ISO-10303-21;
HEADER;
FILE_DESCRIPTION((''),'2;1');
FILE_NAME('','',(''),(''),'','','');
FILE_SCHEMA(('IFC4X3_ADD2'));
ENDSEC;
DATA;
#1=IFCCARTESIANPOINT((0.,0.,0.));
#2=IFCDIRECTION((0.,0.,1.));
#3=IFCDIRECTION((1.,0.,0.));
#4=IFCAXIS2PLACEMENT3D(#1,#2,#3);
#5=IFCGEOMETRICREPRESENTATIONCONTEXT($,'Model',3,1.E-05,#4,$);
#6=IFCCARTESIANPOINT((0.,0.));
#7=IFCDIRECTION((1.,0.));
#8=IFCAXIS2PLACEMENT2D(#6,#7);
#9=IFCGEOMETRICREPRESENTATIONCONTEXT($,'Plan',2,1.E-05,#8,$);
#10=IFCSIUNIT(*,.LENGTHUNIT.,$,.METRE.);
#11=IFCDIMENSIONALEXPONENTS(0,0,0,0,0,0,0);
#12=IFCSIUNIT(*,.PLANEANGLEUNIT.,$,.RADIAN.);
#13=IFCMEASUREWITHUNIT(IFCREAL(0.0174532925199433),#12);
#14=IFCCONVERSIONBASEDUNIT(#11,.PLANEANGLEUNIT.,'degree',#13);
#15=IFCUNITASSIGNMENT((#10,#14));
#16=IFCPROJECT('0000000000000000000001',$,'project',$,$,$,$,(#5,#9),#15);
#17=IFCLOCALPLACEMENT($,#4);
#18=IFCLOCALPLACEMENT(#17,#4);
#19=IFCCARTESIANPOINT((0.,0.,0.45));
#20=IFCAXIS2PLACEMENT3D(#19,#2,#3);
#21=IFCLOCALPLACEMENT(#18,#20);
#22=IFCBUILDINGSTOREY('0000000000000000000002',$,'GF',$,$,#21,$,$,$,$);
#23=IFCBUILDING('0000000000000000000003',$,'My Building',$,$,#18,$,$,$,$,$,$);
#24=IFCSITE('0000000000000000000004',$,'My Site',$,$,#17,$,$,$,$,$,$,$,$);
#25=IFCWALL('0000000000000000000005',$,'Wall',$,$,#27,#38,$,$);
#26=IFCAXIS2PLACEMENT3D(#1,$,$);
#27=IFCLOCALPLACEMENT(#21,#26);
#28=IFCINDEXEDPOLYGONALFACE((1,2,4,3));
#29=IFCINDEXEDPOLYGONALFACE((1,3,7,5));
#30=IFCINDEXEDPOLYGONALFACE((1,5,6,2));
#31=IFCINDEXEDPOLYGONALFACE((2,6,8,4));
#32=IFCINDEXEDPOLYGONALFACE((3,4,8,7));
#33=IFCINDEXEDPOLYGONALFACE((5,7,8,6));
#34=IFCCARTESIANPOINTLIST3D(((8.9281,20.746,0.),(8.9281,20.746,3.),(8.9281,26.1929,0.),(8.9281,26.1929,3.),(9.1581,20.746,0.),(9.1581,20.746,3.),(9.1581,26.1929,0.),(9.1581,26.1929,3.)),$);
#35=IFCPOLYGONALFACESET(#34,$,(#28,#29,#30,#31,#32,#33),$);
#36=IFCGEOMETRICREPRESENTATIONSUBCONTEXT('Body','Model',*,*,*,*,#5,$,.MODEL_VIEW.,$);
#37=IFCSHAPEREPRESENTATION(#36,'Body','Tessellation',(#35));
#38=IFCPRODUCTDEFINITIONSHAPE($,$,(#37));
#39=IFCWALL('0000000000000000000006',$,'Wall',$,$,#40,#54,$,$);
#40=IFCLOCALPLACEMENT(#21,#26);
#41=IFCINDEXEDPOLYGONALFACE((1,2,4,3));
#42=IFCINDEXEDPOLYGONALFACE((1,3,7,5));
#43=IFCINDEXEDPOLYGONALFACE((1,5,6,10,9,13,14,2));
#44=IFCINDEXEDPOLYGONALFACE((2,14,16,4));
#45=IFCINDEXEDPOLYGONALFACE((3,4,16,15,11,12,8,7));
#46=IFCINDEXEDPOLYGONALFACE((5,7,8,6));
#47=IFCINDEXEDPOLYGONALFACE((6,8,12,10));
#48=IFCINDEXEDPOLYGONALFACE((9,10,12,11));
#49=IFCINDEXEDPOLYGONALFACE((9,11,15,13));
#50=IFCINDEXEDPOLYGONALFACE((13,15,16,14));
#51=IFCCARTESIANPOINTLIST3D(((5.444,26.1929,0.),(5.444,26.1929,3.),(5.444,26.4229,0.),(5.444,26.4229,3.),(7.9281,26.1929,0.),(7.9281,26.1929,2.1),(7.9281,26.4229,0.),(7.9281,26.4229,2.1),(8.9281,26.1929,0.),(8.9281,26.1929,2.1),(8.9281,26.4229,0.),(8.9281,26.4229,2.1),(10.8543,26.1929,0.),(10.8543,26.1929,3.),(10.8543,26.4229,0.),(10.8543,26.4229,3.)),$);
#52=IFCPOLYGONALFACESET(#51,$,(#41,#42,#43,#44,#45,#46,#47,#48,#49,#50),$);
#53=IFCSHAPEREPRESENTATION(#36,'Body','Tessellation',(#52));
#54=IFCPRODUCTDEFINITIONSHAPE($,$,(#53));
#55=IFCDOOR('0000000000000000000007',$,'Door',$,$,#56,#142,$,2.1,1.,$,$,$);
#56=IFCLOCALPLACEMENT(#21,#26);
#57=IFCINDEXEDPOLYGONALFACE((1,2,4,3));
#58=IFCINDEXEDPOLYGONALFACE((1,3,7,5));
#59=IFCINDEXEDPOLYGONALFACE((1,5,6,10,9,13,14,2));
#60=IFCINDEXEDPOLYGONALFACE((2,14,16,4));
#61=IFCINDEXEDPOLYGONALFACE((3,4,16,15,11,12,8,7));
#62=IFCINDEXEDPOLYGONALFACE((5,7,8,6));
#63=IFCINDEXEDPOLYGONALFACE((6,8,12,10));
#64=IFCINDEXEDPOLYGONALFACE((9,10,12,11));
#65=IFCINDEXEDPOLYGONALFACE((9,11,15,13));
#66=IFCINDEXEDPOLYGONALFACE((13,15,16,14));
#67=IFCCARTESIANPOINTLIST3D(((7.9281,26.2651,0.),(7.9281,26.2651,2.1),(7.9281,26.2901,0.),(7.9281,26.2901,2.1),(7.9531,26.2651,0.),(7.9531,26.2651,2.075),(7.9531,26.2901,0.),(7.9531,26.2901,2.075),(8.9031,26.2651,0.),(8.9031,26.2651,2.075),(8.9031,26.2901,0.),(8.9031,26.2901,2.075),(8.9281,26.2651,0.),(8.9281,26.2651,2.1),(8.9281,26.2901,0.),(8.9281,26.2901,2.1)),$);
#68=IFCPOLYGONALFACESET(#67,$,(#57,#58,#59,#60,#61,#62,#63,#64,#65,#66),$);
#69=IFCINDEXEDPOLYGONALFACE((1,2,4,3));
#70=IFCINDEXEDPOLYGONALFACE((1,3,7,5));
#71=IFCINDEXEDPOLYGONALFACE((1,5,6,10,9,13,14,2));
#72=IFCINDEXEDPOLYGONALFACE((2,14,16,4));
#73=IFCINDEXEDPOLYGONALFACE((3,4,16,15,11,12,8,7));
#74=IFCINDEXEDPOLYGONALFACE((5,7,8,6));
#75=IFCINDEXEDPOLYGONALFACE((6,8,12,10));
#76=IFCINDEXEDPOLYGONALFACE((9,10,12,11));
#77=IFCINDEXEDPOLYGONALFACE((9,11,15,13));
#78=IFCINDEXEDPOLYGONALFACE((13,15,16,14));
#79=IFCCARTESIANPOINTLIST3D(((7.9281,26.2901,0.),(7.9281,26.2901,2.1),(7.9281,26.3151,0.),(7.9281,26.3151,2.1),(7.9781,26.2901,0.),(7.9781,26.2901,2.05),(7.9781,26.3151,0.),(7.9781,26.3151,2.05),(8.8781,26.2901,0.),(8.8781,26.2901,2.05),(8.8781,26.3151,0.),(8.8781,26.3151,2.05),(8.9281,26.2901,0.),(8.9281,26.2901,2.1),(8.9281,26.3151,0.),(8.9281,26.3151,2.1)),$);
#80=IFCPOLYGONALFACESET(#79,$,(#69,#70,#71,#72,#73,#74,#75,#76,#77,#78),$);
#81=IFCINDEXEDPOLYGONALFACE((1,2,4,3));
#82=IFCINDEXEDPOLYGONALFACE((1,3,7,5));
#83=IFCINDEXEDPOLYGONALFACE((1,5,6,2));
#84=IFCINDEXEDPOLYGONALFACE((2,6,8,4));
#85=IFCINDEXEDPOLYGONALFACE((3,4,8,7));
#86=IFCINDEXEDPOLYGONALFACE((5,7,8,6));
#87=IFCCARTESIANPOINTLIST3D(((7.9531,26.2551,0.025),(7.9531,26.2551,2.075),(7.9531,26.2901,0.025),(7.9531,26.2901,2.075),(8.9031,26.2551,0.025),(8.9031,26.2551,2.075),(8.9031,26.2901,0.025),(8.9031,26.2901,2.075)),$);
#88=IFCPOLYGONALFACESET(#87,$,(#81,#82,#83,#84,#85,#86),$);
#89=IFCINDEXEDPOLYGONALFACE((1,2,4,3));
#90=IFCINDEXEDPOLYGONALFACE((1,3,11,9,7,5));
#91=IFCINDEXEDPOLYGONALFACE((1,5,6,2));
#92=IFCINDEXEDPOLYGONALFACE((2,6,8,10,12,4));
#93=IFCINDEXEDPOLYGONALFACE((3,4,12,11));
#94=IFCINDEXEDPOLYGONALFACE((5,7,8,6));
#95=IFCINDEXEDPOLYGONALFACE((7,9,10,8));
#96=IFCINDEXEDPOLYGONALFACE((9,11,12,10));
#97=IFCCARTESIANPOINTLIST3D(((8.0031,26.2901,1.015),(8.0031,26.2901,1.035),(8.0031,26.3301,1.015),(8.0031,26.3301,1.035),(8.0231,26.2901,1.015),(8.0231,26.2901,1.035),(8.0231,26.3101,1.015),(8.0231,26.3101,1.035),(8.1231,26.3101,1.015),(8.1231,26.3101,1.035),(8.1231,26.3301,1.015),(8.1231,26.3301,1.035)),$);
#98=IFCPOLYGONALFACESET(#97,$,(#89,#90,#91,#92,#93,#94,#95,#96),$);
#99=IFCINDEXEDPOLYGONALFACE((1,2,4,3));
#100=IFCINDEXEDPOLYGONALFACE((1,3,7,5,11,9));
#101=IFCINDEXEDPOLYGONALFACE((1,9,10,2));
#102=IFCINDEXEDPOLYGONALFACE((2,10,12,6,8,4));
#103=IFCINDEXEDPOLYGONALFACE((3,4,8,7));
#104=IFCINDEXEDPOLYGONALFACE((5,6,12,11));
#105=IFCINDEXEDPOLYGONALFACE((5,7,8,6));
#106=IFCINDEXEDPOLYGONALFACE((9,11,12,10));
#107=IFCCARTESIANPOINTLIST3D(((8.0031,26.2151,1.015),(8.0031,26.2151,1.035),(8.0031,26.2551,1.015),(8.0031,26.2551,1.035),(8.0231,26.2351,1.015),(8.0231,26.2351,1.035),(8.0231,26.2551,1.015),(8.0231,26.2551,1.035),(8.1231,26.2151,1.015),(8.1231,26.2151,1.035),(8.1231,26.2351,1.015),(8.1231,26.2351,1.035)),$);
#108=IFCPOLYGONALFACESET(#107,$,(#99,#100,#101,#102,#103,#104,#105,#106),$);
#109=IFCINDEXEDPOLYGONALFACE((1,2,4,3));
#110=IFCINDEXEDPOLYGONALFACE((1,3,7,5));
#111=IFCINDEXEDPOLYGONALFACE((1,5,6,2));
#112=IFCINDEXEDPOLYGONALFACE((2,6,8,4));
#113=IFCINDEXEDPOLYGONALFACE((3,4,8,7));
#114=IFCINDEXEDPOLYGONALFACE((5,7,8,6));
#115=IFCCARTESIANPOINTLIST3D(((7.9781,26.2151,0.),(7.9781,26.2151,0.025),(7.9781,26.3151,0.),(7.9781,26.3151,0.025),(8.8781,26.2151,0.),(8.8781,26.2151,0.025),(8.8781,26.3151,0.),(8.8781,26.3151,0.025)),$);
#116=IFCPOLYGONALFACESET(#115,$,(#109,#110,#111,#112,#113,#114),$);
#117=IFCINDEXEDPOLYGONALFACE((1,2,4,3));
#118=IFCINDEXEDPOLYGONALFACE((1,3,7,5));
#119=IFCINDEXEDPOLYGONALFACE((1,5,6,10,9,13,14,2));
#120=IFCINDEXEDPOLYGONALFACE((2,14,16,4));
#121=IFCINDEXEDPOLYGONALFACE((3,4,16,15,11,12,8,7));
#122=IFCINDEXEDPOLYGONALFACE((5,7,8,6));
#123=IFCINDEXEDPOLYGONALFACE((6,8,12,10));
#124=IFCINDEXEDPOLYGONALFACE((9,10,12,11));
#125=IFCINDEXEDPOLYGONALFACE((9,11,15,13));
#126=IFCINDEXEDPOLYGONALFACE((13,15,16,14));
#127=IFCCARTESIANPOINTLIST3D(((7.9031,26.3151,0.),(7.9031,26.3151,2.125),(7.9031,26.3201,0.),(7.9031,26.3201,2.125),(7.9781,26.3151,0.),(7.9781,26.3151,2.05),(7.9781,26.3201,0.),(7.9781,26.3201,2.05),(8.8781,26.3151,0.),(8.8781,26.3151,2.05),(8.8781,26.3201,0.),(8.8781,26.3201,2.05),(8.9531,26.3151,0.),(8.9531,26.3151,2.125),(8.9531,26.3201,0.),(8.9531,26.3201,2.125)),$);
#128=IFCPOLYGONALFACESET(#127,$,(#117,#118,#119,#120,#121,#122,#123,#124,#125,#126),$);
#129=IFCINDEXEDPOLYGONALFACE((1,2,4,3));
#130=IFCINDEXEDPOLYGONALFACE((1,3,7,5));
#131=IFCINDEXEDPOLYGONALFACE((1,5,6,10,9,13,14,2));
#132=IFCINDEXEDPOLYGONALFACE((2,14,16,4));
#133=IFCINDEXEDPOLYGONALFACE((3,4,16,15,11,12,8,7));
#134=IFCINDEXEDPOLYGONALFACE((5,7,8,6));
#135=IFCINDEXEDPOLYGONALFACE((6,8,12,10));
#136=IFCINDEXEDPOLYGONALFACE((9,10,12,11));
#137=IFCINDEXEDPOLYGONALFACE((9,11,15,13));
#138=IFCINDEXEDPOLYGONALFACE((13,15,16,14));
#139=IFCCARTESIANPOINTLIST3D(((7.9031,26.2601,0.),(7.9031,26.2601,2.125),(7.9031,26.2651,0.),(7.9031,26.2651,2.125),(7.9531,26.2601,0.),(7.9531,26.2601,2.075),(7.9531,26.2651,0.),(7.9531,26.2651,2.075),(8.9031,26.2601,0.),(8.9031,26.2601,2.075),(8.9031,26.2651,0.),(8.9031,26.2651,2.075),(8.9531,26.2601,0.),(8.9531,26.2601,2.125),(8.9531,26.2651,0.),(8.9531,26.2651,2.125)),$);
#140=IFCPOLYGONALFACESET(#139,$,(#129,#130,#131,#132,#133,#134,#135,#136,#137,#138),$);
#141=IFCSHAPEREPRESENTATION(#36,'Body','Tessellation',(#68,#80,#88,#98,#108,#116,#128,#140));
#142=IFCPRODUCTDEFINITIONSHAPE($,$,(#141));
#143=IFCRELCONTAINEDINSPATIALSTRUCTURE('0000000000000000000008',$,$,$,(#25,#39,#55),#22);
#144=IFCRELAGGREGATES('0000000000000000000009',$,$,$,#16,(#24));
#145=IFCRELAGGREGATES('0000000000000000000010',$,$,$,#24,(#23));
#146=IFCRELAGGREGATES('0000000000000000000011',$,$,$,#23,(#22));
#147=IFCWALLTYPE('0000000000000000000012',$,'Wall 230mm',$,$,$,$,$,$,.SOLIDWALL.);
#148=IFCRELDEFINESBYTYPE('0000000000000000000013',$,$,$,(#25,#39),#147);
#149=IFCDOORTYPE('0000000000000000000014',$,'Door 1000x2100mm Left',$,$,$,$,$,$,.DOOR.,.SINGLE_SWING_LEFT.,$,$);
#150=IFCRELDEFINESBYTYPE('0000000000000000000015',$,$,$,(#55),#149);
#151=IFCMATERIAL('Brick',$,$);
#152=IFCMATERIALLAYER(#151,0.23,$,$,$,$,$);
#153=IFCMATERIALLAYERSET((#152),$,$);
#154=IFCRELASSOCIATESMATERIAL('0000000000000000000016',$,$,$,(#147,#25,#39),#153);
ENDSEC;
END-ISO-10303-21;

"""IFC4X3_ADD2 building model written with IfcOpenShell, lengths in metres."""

from ifc_helpers import new_model, entity, si_unit, converted_unit, frame, origin_with_axes, origin_2d_with_axis, place, context, subcontext, project, spatial, line, indexed_curve, outline, extrude, shape, source, transform, mapped, material, layer, layer_set, layer_usage, type_object, type_shapes, element, fill, save


model = new_model("IFC4X3_ADD2")

# Units and contexts
model_context = context("Model", 3, precision=1e-05, world=origin_with_axes())
plan_context = context("Plan", 2, precision=1e-05, world=origin_2d_with_axis())
body_context_1 = subcontext(model_context, "Body", "Model", "MODEL_VIEW")
body_context_2 = subcontext(plan_context, "Body", "Plan", "PLAN_VIEW")
ifc_project = project(units=[si_unit("LENGTHUNIT", "METRE"), converted_unit("PLANEANGLEUNIT", "degree", entity("IfcReal", 0.0174532925199433), si_unit("PLANEANGLEUNIT", "RADIAN"), dimensions=[0, 0, 0, 0, 0, 0, 0])], contexts=[model_context, plan_context])

# Site, building, storey
site_placement = place(None, origin_with_axes())
site = spatial("IfcSite", under=ifc_project, at=site_placement, Name="My Site")
building_placement = place(site_placement, origin_with_axes())
building = spatial("IfcBuilding", under=site, at=building_placement, Name="My Building")
storey_placement = place(building_placement, frame((0.0, 0.0, 0.45), z_axis=(0.0, 0.0, 1.0), x_axis=(1.0, 0.0, 0.0)))
storey = spatial("IfcBuildingStorey", under=building, at=storey_placement, Name="GF")

# Wall
ifc_material = material(Name="Brick")
ifc_layer_1 = layer(ifc_material, 0.23)
ifc_layer_set_1 = layer_set([ifc_layer_1])
ifc_layer_usage_1 = layer_usage(ifc_layer_set_1, "AXIS2", "POSITIVE", 0.0)
wall_type_1 = type_object("IfcWallType", Name="Wall 230mm", PredefinedType="SOLIDWALL", material=ifc_layer_set_1)
wall_1_placement = place(storey_placement, frame((9.1581, 20.746, 0.0), z_axis=(0.0, 0.0, 1.0), x_axis=(0.0, 1.0, 0.0)))
element("IfcWall", 1, at=wall_1_placement, inside=storey, type_object=wall_type_1, material=ifc_layer_usage_1, Name="Wall", context=body_context_1, shape_type="SweptSolid", body=[
    extrude(outline(indexed_curve([(0.0, 0.0), (0.0, 0.23), (5.4469, 0.23), (5.4469, 0.0), (0.0, 0.0)], self_intersect=False)), origin_with_axes(), (0.0, 0.0, 1.0), 3.0),
])

# Wall, opening, door
ifc_layer_usage_2 = layer_usage(ifc_layer_set_1, "AXIS2", "POSITIVE", 0.0)
wall_2_placement = place(storey_placement, frame((5.444, 26.1929, 0.0), z_axis=(0.0, 0.0, 1.0), x_axis=(1.0, 0.0, 0.0)))
wall_2 = element("IfcWall", 2, at=wall_2_placement, inside=storey, type_object=wall_type_1, material=ifc_layer_usage_2, Name="Wall", context=body_context_1, shape_type="SweptSolid", body=[
    extrude(outline(indexed_curve([(0.0, 0.0), (0.0, 0.23), (5.4103, 0.23), (5.4103, 0.0), (0.0, 0.0)], self_intersect=False)), origin_with_axes(), (0.0, 0.0, 1.0), 3.0),
])
shared_shape_1 = source(origin_with_axes(), body_context_1, "Body", "SweptSolid", [
    extrude(outline(indexed_curve([(0.0, 0.0), (1.0, 0.0), (1.0, 2.1), (0.0, 2.1)], segments=[line(1, 2, 3, 4, 1)])), frame((0.0, -0.6, 0.0), z_axis=(0.0, -1.0, 0.0), x_axis=(1.0, 0.0, 0.0)), (0.0, 0.0, -1.0), 1.2),
])
opening_1_placement = place(wall_2_placement, frame((3.4841, 0.1222, 0.0), z_axis=(0.0, 0.0, 1.0), x_axis=(-1.0, 0.0, 0.0)))
opening_1 = element("IfcOpeningElement", 3, at=opening_1_placement, cuts=wall_2, PredefinedType="OPENING", context=body_context_1, shape_type="MappedRepresentation", body=[
    mapped(shared_shape_1, transform((0.0, 0.0, 0.0), x_axis=(1.0, 0.0, 0.0), y_axis=(0.0, 1.0, 0.0), z_axis=(0.0, 0.0, 1.0), scale=1.0)),
])
door_type_1 = type_object("IfcDoorType", Name="Door 1000x2100mm Left", OperationType="SINGLE_SWING_LEFT", PredefinedType="DOOR")
shared_shape_2 = source(origin_with_axes(), body_context_1, "Body", "SweptSolid", [
    extrude(outline(indexed_curve([(0.0, 0.0), (0.0, 2.1), (1.0, 2.1), (1.0, 0.0), (0.975, 0.0), (0.975, 2.075), (0.025, 2.075), (0.025, 0.0)], segments=[line(1, 2, 3, 4, 5, 6, 7, 8, 1)])), frame((0.0, 0.025, 0.0), z_axis=(0.0, -1.0, 0.0), x_axis=(1.0, 0.0, 0.0)), (0.0, 0.0, -1.0), 0.025),
    extrude(outline(indexed_curve([(0.0, 0.0), (0.0, 2.1), (1.0, 2.1), (1.0, 0.0), (0.95, 0.0), (0.95, 2.05), (0.05, 2.05), (0.05, 0.0)], segments=[line(1, 2, 3, 4, 5, 6, 7, 8, 1)])), frame((0.0, 0.0, 0.0), z_axis=(0.0, -1.0, 0.0), x_axis=(1.0, 0.0, 0.0)), (0.0, 0.0, -1.0), 0.025),
    extrude(outline(indexed_curve([(0.0, 0.0), (0.95, 0.0), (0.95, 0.035), (0.0, 0.035)], segments=[line(1, 2, 3, 4, 1)])), frame((0.025, 0.025, 0.025), z_axis=(0.0, 0.0, 1.0), x_axis=(1.0, 0.0, 0.0)), (0.0, 0.0, 1.0), 2.05),
    extrude(outline(indexed_curve([(0.0, 0.0), (0.0, -0.04), (-0.12, -0.04), (-0.12, -0.02), (-0.02, -0.02), (-0.02, 0.0)], segments=[line(1, 2, 3, 4, 5, 6, 1)])), frame((0.925, 0.025, 1.015), z_axis=(0.0, 0.0, 1.0), x_axis=(1.0, 0.0, 0.0)), (0.0, 0.0, 1.0), 0.02),
    extrude(outline(indexed_curve([(0.0, 0.0), (0.0, 0.04), (-0.12, 0.04), (-0.12, 0.02), (-0.02, 0.02), (-0.02, 0.0)], segments=[line(1, 2, 3, 4, 5, 6, 1)])), frame((0.925, 0.06, 1.015), z_axis=(0.0, 0.0, 1.0), x_axis=(1.0, 0.0, 0.0)), (0.0, 0.0, 1.0), 0.02),
    extrude(outline(indexed_curve([(0.0, 0.0), (0.9, 0.0), (0.9, 0.1), (0.0, 0.1)], segments=[line(1, 2, 3, 4, 1)])), frame((0.05, 0.0, 0.0), z_axis=(0.0, 0.0, 1.0), x_axis=(1.0, 0.0, 0.0)), (0.0, 0.0, 1.0), 0.025),
    extrude(outline(indexed_curve([(0.0, 0.0), (0.0, 2.125), (1.05, 2.125), (1.05, 0.0), (0.975, 0.0), (0.975, 2.05), (0.075, 2.05), (0.075, 0.0)], segments=[line(1, 2, 3, 4, 5, 6, 7, 8, 1)])), frame((-0.025, -0.005, 0.0), z_axis=(0.0, -1.0, 0.0), x_axis=(1.0, 0.0, 0.0)), (0.0, 0.0, -1.0), 0.005),
    extrude(outline(indexed_curve([(0.0, 0.0), (0.0, 2.125), (1.05, 2.125), (1.05, 0.0), (1.0, 0.0), (1.0, 2.075), (0.05, 2.075), (0.05, 0.0)], segments=[line(1, 2, 3, 4, 5, 6, 7, 8, 1)])), frame((-0.025, 0.05, 0.0), z_axis=(0.0, -1.0, 0.0), x_axis=(1.0, 0.0, 0.0)), (0.0, 0.0, -1.0), 0.005),
])
shared_shape_3 = source(origin_with_axes(), body_context_2, "Body", "Curve2D", [
    entity("IfcIndexedPolyCurve", entity("IfcCartesianPointList2D", [[0.0, 0.0], [0.0, 0.05], [0.025, 0.05], [0.025, 0.025], [0.05, 0.025], [0.05, 0.0]]), [entity("IfcLineIndex", [1, 2, 3, 4, 5, 6, 1])]),
    entity("IfcIndexedPolyCurve", entity("IfcCartesianPointList2D", [[1.0, 0.0], [1.0, 0.05], [0.975, 0.05], [0.975, 0.025], [0.95, 0.025], [0.95, 0.0]]), [entity("IfcLineIndex", [1, 2, 3, 4, 5, 6, 1])]),
    entity("IfcTrimmedCurve", entity("IfcEllipse", entity("IfcAxis2Placement2D", entity("IfcCartesianPoint", [0.06, 0.05]), entity("IfcDirection", [1.0, 0.0])), 0.915, 0.95), [entity("IfcCartesianPoint", [0.975, 0.05])], [entity("IfcCartesianPoint", [0.06, 1.0])], True, "CARTESIAN"),
    entity("IfcIndexedPolyCurve", entity("IfcCartesianPointList2D", [[0.025, 0.05], [0.06, 0.05], [0.06, 1.0], [0.025, 1.0]]), [entity("IfcLineIndex", [1, 2, 3, 4, 1])]),
])
type_shapes(door_type_1, [shared_shape_2, shared_shape_3])
door_1_placement = place(opening_1_placement, frame((0.0, 0.0, 0.0), z_axis=(0.0, 0.0, 1.0), x_axis=(1.0, 0.0, 0.0)))
door_1 = element("IfcDoor", 4, at=door_1_placement, inside=storey, type_object=door_type_1, Name="Door", OverallHeight=2.1, OverallWidth=1.0, shapes=[
    shape(body_context_1, "Body", "MappedRepresentation", [mapped(shared_shape_2, transform((0.0, 0.0, 0.0), x_axis=(1.0, 0.0, 0.0), y_axis=(0.0, 1.0, 0.0), z_axis=(0.0, 0.0, 1.0), scale=1.0))]),
    shape(body_context_2, "Body", "MappedRepresentation", [mapped(shared_shape_3, transform((0.0, 0.0, 0.0), x_axis=(1.0, 0.0, 0.0), y_axis=(0.0, 1.0, 0.0), z_axis=(0.0, 0.0, 1.0), scale=1.0))]),
])
fill(opening_1, door_1)

save(model, "model.ifc")
